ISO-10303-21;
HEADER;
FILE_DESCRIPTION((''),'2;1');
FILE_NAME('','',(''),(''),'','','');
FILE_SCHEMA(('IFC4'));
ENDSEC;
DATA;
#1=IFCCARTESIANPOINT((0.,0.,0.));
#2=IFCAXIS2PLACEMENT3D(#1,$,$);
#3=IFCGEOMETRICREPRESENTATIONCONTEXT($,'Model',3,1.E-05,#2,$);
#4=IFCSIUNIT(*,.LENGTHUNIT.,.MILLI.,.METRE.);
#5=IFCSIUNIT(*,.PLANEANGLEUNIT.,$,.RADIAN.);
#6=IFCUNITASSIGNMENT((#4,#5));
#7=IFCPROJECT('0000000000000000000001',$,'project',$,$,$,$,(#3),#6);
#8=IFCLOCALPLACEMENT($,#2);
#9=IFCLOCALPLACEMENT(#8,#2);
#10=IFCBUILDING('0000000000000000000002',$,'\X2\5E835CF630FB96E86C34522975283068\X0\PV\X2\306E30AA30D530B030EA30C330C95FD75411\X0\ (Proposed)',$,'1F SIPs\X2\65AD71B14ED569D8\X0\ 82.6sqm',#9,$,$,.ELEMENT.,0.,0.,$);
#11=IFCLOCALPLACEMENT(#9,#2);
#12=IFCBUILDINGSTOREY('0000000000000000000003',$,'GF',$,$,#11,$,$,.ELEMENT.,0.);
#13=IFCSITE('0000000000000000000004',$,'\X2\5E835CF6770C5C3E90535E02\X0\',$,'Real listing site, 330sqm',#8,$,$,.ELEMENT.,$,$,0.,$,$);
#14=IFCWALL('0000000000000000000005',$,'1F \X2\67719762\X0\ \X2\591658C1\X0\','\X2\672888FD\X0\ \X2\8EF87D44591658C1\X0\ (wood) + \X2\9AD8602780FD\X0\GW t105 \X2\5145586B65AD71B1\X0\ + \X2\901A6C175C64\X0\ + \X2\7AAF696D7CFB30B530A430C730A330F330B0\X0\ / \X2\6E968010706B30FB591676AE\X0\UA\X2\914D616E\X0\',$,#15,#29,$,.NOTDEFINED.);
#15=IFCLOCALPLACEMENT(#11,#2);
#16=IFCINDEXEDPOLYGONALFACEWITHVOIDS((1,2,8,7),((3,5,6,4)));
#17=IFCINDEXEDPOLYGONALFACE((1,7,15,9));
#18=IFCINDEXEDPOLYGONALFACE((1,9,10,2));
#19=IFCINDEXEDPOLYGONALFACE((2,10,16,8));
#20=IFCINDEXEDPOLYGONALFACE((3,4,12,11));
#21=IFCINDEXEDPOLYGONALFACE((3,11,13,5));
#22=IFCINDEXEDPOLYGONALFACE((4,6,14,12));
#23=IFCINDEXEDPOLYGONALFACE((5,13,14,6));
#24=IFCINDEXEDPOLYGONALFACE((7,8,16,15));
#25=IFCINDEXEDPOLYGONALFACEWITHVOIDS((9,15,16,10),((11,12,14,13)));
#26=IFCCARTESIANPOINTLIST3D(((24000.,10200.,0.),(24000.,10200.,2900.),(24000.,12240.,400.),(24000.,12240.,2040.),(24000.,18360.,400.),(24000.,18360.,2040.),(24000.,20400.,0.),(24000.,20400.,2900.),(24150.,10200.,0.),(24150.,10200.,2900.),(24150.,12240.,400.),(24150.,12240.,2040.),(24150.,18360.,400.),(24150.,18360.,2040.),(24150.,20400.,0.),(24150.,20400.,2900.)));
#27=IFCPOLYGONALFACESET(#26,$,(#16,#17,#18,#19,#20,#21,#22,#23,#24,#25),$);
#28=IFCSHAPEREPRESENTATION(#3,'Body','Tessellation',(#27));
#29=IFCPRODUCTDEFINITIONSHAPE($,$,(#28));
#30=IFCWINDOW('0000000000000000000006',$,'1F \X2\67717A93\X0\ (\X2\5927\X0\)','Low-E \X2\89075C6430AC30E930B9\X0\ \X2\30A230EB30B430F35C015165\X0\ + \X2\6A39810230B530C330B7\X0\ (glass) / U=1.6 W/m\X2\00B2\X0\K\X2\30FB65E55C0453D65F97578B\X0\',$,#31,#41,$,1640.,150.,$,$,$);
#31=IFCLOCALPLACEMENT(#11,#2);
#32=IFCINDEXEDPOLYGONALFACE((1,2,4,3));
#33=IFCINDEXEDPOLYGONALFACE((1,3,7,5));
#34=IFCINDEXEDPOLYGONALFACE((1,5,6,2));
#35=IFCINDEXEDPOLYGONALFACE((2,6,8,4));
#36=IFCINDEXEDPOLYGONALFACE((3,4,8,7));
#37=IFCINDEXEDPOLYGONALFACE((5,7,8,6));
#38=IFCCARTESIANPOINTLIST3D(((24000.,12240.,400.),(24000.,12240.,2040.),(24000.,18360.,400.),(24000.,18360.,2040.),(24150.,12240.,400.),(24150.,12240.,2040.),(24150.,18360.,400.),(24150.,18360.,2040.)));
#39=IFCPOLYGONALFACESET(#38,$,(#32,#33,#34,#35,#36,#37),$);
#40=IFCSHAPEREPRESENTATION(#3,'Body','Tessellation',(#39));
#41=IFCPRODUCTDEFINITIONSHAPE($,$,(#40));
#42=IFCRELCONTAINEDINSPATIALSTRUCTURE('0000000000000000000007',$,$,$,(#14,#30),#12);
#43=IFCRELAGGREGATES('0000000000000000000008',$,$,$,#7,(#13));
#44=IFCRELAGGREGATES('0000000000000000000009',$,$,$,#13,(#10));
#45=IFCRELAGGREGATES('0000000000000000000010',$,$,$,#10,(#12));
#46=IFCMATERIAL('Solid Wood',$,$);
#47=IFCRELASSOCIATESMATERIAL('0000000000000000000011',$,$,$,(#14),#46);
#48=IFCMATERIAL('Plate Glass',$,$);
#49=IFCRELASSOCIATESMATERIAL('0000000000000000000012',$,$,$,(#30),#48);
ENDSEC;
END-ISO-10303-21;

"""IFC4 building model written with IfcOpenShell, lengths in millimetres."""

from ifc_helpers import new_model, si_unit, frame, frame_2d, origin, place, context, project, spatial, rectangle, extrude, material, element, fill, save


model = new_model("IFC4")

# Units and contexts
model_context = context("Model", 3, precision=1e-05, world=origin())
ifc_project = project(units=[si_unit("LENGTHUNIT", "METRE", prefix="MILLI"), si_unit("PLANEANGLEUNIT", "RADIAN")], contexts=[model_context])

# Site, building, storey
site_placement = place(None, origin())
site = spatial("IfcSite", under=ifc_project, at=site_placement, Name="広島県尾道市", ObjectType="Real listing site, 330sqm", CompositionType="ELEMENT", RefElevation=0.0)
building_placement = place(site_placement, origin())
building = spatial("IfcBuilding", under=site, at=building_placement, Name="広島・雨水利用とPVのオフグリッド志向 (Proposed)", ObjectType="1F SIPs断熱仕様 82.6sqm", CompositionType="ELEMENT", ElevationOfRefHeight=0.0, ElevationOfTerrain=0.0)
storey_placement = place(building_placement, origin())
storey = spatial("IfcBuildingStorey", under=building, at=storey_placement, Name="GF", CompositionType="ELEMENT", Elevation=0.0)

# Shared definitions
ifc_material_1 = material(Name="Solid Wood")

# Wall, opening, window
wall_1_placement = place(storey_placement, frame((12000.0, 5100.0, 0.0)))
wall_1 = element("IfcWall", 1, at=wall_1_placement, inside=storey, material=ifc_material_1, Name="1F 東面 外壁", Description="木製 軸組外壁 (wood) + 高性能GW t105 充填断熱 + 通気層 + 窯業系サイディング / 準耐火・外皮UA配慮", PredefinedType="NOTDEFINED", context=model_context, shape_type="SweptSolid", body=[
    extrude(rectangle(XDim=150.0, YDim=10200.0, at=frame_2d((75.0, 5100.0))), frame((12000.0, 5100.0, 0.0)), (0.0, 0.0, 1.0), 2900.0),
])
opening_placement = place(storey_placement, frame((12000.0, 6120.0, 200.0)))
opening = element("IfcOpeningElement", 2, at=opening_placement, cuts=wall_1, PredefinedType="NOTDEFINED", context=model_context, shape_type="SweptSolid", body=[
    extrude(rectangle(XDim=150.0, YDim=6120.0, at=frame_2d((75.0, 3060.0))), frame((12000.0, 6120.0, 200.0)), (0.0, 0.0, 1.0), 1640.0),
])
ifc_material_2 = material(Name="Plate Glass")
window_placement = place(storey_placement, frame((12000.0, 6120.0, 200.0)))
window = element("IfcWindow", 3, at=window_placement, inside=storey, material=ifc_material_2, Name="1F 東窓 (大)", Description="Low-E 複層ガラス アルゴン封入 + 樹脂サッシ (glass) / U=1.6 W/m²K・日射取得型", OverallHeight=1640.0, OverallWidth=150.0, context=model_context, shape_type="SweptSolid", body=[
    extrude(rectangle(XDim=150.0, YDim=6120.0, at=frame_2d((75.0, 3060.0))), frame((12000.0, 6120.0, 200.0)), (0.0, 0.0, 1.0), 1640.0),
])
fill(opening, window)

save(model, "model.ifc")
